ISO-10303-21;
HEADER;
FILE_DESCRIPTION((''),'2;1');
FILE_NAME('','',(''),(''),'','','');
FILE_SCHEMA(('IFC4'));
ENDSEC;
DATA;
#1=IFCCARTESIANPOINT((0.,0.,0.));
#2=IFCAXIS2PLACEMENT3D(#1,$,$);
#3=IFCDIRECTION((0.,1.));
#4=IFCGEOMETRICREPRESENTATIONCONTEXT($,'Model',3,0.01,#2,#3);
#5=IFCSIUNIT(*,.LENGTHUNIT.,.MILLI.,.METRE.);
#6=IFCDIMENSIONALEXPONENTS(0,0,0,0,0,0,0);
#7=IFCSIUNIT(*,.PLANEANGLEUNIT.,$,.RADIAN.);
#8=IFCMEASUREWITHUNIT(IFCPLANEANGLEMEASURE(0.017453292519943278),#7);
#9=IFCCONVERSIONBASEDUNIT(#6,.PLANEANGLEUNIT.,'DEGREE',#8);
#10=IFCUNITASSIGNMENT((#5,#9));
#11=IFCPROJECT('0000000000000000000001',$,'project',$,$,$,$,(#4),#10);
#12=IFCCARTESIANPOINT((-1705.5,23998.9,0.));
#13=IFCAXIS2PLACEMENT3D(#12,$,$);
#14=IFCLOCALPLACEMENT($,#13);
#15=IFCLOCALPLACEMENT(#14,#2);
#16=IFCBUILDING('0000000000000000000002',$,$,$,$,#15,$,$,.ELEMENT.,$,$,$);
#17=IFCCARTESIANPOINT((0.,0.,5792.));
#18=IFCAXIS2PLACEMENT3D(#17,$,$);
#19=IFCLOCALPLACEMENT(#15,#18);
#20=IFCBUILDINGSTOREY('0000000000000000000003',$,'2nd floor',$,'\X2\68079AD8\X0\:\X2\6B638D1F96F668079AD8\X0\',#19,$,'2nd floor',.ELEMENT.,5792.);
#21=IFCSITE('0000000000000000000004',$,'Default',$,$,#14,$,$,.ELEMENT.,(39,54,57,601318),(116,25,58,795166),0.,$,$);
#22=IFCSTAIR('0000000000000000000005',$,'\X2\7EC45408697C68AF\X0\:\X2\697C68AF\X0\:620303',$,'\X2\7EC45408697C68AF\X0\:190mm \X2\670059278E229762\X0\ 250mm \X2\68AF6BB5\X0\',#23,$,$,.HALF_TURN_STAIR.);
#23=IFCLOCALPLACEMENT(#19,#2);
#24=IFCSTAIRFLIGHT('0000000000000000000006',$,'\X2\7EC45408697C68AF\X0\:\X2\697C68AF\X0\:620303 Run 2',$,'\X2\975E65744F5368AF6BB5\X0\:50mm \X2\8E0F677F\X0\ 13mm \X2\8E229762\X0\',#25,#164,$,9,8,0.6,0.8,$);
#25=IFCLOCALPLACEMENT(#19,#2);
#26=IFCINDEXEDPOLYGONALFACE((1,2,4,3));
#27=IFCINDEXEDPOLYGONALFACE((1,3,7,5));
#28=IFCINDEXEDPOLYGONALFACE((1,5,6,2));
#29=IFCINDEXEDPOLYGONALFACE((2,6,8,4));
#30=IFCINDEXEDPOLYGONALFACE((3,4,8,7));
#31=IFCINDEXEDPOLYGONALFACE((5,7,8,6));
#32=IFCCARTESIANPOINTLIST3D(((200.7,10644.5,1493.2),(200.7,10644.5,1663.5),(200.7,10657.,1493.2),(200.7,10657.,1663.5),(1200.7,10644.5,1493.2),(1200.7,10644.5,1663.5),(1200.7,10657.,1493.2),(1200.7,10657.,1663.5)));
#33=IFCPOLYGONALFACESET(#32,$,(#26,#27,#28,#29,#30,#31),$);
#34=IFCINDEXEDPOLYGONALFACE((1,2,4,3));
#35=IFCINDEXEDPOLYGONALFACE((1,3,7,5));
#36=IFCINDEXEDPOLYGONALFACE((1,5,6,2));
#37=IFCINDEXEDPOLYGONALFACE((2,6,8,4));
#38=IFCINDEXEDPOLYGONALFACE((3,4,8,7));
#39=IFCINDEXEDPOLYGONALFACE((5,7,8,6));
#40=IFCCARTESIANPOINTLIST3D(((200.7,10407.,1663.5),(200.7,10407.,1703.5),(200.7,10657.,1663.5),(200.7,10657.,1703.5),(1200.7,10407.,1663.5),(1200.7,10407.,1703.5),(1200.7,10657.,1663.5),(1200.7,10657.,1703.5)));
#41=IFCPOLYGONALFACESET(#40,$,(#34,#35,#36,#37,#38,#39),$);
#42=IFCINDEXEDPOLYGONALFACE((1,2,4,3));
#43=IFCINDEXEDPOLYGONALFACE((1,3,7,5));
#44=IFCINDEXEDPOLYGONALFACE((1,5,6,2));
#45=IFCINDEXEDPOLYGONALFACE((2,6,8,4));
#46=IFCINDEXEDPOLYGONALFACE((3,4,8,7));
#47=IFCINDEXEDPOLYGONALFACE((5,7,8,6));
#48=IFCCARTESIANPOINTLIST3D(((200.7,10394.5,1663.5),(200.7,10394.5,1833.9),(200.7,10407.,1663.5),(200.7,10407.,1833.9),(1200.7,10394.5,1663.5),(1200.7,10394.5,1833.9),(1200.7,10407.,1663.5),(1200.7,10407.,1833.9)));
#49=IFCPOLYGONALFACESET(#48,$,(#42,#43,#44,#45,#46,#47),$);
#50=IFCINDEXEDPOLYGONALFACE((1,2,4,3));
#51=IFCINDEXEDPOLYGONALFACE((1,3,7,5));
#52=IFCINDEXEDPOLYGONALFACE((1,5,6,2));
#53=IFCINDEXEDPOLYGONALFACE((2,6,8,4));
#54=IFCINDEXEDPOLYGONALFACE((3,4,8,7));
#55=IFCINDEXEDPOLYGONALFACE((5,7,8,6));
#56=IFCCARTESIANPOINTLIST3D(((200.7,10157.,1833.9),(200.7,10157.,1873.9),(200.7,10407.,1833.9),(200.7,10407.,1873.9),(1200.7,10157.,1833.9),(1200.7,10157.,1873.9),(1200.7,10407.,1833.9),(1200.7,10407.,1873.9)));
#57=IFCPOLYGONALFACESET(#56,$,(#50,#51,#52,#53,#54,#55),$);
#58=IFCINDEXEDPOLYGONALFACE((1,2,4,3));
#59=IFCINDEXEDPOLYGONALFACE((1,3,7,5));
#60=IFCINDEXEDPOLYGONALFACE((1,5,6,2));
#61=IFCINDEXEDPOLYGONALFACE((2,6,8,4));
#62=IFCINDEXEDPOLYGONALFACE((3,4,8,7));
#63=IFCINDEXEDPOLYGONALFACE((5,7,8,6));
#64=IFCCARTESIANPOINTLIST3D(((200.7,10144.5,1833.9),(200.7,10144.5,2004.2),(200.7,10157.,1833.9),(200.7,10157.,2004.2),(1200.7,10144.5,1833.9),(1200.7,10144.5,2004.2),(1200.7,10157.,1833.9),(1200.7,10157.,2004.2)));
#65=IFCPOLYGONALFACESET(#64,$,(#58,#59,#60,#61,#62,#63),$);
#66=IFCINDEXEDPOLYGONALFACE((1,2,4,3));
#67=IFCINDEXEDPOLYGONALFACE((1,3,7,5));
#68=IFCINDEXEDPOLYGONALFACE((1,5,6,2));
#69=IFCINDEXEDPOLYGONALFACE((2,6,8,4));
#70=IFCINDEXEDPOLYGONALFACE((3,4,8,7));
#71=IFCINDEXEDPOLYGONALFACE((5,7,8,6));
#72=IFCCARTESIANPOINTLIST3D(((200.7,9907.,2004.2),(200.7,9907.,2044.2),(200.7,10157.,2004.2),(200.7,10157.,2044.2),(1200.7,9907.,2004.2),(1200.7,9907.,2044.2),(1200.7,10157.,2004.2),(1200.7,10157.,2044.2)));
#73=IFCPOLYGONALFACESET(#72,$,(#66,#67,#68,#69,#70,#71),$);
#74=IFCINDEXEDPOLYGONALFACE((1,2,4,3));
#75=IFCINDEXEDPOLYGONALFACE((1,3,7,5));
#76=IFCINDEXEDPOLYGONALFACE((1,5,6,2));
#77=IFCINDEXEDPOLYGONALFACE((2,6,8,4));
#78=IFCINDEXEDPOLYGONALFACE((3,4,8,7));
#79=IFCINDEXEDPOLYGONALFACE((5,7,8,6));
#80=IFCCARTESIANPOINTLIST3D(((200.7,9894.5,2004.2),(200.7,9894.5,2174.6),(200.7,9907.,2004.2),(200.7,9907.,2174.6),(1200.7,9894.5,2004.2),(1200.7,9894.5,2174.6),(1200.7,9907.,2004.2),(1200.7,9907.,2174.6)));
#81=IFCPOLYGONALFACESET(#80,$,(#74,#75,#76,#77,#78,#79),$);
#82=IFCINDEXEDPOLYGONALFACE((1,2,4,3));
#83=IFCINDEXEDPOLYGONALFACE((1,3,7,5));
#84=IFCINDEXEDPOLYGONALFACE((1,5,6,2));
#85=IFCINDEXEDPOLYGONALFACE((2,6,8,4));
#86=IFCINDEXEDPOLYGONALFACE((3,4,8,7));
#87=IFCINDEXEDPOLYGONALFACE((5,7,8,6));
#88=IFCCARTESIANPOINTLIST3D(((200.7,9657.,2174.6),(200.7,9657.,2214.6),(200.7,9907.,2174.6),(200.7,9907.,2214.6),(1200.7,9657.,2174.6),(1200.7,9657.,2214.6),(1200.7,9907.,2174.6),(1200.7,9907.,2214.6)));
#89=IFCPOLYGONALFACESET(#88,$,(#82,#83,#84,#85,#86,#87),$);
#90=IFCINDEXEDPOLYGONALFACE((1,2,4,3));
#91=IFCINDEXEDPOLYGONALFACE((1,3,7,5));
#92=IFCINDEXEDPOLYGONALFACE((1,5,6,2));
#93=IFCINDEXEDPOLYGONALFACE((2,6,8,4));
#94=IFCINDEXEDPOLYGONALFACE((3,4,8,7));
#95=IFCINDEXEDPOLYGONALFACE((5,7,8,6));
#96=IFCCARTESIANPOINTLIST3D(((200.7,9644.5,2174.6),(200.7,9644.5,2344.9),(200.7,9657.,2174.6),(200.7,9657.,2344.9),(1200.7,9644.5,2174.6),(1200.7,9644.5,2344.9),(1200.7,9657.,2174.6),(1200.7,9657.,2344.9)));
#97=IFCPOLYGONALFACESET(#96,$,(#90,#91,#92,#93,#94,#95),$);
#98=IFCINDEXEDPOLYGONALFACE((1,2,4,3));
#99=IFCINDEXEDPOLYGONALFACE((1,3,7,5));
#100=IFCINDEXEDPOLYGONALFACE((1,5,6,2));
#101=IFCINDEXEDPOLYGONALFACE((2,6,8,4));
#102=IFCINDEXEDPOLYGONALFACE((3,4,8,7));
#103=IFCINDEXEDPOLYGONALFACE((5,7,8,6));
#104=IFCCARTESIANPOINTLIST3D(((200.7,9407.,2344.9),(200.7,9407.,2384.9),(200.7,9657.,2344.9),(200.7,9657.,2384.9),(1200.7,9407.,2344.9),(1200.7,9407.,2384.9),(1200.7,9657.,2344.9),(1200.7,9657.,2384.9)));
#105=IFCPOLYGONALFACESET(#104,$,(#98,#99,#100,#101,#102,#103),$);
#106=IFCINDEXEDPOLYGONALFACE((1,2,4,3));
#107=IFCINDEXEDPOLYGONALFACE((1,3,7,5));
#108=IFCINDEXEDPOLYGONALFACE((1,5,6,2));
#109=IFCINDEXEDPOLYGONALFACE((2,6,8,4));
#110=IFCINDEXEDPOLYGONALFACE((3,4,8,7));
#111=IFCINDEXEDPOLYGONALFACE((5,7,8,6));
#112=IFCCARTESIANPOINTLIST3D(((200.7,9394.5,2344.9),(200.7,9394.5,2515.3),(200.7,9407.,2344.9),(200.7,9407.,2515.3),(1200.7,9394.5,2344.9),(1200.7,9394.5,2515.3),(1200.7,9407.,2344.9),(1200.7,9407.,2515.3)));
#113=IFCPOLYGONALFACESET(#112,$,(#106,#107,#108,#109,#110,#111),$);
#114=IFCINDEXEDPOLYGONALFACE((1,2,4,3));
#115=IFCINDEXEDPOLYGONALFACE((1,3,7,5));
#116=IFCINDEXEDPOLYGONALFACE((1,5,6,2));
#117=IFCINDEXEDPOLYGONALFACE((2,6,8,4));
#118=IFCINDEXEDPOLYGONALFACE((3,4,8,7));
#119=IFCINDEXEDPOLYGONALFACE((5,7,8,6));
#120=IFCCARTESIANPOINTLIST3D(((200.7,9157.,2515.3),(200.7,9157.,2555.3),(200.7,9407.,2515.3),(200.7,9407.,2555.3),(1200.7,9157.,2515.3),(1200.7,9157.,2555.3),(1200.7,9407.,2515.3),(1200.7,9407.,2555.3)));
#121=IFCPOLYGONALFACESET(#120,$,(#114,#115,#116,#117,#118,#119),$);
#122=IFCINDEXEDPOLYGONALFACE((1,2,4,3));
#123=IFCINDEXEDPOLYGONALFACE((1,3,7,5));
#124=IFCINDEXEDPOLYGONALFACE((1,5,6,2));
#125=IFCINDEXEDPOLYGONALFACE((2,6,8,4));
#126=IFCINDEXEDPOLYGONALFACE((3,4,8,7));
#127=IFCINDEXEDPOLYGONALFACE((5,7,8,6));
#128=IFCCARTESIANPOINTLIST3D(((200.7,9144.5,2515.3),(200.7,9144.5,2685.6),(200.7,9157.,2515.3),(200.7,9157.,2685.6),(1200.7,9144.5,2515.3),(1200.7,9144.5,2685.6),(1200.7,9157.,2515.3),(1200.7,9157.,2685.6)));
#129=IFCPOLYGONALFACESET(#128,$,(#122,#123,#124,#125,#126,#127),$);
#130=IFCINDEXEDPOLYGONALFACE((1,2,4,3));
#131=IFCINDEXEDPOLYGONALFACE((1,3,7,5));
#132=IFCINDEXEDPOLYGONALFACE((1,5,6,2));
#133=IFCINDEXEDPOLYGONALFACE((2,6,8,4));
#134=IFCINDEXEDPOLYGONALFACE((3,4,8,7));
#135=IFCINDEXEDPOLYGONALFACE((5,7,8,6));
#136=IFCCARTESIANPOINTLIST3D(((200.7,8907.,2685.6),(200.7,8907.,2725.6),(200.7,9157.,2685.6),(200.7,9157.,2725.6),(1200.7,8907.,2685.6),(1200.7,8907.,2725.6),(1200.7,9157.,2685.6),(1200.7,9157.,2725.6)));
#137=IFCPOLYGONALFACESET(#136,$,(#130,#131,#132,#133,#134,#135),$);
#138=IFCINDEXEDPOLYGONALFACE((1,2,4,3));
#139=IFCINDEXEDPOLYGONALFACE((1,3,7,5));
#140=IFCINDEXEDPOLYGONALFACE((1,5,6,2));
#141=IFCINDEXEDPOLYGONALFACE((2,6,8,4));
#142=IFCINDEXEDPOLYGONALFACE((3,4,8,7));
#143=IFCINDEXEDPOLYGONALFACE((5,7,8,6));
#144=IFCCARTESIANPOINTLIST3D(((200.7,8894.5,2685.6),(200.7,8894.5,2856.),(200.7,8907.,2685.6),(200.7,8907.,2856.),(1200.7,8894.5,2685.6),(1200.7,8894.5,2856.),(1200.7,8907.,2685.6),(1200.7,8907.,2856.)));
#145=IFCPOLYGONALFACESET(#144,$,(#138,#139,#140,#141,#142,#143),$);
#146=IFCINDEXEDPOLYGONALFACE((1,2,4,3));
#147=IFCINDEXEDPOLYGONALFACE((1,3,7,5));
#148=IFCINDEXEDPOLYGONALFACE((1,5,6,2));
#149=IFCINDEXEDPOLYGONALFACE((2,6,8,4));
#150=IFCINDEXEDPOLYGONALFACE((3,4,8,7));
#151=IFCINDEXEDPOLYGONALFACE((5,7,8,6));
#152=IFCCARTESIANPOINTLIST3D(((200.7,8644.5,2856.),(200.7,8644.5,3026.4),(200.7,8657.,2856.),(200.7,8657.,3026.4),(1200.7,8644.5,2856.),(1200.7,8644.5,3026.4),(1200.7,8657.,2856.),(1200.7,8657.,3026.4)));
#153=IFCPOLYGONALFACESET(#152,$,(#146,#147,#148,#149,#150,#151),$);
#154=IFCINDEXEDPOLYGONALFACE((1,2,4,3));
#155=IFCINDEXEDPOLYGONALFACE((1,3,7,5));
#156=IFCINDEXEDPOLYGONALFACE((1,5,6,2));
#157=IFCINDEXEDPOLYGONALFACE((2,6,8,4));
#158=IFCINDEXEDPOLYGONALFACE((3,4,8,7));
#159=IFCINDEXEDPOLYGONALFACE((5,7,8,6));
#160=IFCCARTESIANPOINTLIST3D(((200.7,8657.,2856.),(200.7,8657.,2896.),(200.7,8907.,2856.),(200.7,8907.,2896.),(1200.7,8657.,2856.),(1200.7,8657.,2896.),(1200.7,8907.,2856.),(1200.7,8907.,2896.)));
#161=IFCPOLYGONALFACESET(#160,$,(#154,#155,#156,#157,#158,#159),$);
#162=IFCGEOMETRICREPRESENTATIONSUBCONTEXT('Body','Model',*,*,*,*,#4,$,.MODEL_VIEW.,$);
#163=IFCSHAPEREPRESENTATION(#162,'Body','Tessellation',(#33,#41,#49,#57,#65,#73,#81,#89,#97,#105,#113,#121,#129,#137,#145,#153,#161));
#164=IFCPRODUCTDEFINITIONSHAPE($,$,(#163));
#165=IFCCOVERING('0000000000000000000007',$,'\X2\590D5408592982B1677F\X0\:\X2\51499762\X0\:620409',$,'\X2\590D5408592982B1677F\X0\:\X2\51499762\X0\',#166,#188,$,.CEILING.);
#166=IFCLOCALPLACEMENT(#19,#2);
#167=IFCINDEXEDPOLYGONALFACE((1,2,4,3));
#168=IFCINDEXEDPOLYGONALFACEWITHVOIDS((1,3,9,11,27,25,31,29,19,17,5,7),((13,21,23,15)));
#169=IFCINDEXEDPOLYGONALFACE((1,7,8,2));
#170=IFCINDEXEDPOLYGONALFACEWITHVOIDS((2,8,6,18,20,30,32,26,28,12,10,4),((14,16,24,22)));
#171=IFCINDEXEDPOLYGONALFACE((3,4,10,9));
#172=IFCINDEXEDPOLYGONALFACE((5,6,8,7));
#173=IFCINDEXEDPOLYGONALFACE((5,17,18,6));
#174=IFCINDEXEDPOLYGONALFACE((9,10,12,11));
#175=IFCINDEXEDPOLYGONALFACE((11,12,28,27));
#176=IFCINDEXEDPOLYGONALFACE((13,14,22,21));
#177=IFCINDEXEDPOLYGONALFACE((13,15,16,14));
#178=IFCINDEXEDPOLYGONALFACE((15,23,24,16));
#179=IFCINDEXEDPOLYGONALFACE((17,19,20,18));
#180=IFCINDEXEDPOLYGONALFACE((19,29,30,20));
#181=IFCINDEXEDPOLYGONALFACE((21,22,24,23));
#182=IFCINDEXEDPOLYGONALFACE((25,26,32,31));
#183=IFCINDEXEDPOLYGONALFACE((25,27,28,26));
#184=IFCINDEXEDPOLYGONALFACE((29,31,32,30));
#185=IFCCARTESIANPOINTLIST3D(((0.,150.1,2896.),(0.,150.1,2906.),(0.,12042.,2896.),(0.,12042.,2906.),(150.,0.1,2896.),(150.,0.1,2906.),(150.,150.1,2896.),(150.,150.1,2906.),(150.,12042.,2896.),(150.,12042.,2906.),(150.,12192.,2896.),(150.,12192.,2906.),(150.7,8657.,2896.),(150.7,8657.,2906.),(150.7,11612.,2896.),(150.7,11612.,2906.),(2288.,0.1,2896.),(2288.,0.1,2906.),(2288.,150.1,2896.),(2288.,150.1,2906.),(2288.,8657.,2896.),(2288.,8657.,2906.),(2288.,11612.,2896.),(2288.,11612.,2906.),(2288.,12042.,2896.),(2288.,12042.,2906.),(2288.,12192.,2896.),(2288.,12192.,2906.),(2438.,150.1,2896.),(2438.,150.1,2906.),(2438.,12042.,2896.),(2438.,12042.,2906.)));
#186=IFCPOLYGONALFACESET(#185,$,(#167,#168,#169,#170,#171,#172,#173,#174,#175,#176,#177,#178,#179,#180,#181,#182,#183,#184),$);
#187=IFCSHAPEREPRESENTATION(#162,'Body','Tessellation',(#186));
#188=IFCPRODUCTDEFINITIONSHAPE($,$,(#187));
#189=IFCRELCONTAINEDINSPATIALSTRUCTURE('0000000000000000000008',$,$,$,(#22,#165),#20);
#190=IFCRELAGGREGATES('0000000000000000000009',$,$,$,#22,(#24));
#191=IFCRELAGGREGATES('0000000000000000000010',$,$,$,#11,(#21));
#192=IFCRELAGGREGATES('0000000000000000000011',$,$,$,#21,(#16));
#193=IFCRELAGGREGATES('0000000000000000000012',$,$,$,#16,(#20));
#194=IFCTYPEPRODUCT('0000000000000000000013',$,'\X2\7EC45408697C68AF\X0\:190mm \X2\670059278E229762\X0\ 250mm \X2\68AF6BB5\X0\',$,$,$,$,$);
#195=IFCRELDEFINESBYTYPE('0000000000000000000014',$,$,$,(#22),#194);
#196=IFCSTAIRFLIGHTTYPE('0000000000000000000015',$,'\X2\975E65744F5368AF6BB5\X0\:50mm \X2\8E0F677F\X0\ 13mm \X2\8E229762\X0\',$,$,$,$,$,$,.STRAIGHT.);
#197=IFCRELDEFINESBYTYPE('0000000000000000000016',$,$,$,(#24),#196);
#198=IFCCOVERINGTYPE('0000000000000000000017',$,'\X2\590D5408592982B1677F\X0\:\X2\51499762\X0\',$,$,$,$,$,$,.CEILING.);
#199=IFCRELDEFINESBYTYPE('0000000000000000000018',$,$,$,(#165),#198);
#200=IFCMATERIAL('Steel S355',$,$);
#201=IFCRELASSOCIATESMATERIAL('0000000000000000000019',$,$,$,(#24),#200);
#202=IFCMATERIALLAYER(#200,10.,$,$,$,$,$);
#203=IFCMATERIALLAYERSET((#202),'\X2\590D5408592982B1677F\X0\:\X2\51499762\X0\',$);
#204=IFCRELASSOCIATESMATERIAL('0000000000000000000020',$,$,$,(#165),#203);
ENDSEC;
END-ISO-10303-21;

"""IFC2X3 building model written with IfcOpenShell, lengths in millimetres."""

from ifc_helpers import new_model, entity, si_unit, converted_unit, direction, frame, frame_2d, origin, origin_2d_with_axis, place, context, subcontext, project, spatial, polyline, rectangle, outline, extrude, material, layer, layer_set, layer_usage, type_object, element, aggregate, save


model = new_model("IFC2X3")

# Units and contexts
model_context = context("Model", 3, precision=0.01, world=origin(), true_north=direction((0.0, 1.0)))
body_context = subcontext(model_context, "Body", "Model", "MODEL_VIEW")
ifc_project = project(units=[si_unit("LENGTHUNIT", "METRE", prefix="MILLI"), converted_unit("PLANEANGLEUNIT", "DEGREE", entity("IfcPlaneAngleMeasure", 0.017453292519943278), si_unit("PLANEANGLEUNIT", "RADIAN"), dimensions=[0, 0, 0, 0, 0, 0, 0])], contexts=[model_context])

# Site, building, storey
site_placement = place(None, frame((-1705.5, 23998.9, 0.0)))
site = spatial("IfcSite", under=ifc_project, at=site_placement, Name="Default", CompositionType="ELEMENT", RefLatitude=(39, 54, 57, 601318), RefLongitude=(116, 25, 58, 795166), RefElevation=0.0)
building_placement = place(site_placement, origin())
building = spatial("IfcBuilding", under=site, at=building_placement, CompositionType="ELEMENT")
storey_placement = place(building_placement, frame((0.0, 0.0, 5792.0)))
storey = spatial("IfcBuildingStorey", under=building, at=storey_placement, Name="2nd floor", ObjectType="标高:正负零标高", LongName="2nd floor", CompositionType="ELEMENT", Elevation=5792.0)

# Stair
type_product = type_object("IfcTypeProduct", Name="组合楼梯:190mm 最大踢面 250mm 梯段")
stair_placement = place(storey_placement, origin())
stair = element("IfcStair", 1, at=stair_placement, inside=storey, type_object=type_product, Name="组合楼梯:楼梯:620303", ObjectType="组合楼梯:190mm 最大踢面 250mm 梯段", ShapeType="HALF_TURN_STAIR")
ifc_material_1 = material(Name="Steel S355")

# Stair flight
stair_flight_type = type_object("IfcStairFlightType", Name="非整体梯段:50mm 踏板 13mm 踢面", PredefinedType="STRAIGHT")
stair_flight_1_placement = place(stair_placement, origin())
stair_flight_1 = element("IfcStairFlight", 2, at=stair_flight_1_placement, type_object=stair_flight_type, material=ifc_material_1, Name="组合楼梯:楼梯:620303 Run 2", ObjectType="非整体梯段:50mm 踏板 13mm 踢面", NumberOfRiser=9, NumberOfTreads=8, RiserHeight=0.6, TreadLength=0.8, context=body_context, shape_type="SweptSolid", body=[
    extrude(rectangle(XDim=1000.0, YDim=12.5, at=frame_2d((0.0, 0.0), x_axis=(1.0, 0.0))), frame((700.7, 10650.7, 1493.2)), (0.0, 0.0, 1.0), 170.4),
    extrude(rectangle(XDim=250.0, YDim=1000.0, at=frame_2d((0.0, 0.0), x_axis=(1.0, 0.0))), frame((700.7, 10532.0, 1663.5), z_axis=(0.0, 0.0, 1.0), x_axis=(0.0, 1.0, 0.0)), (0.0, 0.0, 1.0), 40.0),
    extrude(rectangle(XDim=1000.0, YDim=12.5, at=frame_2d((0.0, 0.0), x_axis=(1.0, 0.0))), frame((700.7, 10400.7, 1663.5)), (0.0, 0.0, 1.0), 170.4),
    extrude(rectangle(XDim=250.0, YDim=1000.0, at=origin_2d_with_axis()), frame((700.7, 10282.0, 1833.9), z_axis=(0.0, 0.0, 1.0), x_axis=(0.0, 1.0, 0.0)), (0.0, 0.0, 1.0), 40.0),
    extrude(rectangle(XDim=1000.0, YDim=12.5, at=frame_2d((0.0, 0.0), x_axis=(1.0, 0.0))), frame((700.7, 10150.7, 1833.9)), (0.0, 0.0, 1.0), 170.4),
    extrude(rectangle(XDim=250.0, YDim=1000.0, at=frame_2d((0.0, 0.0), x_axis=(1.0, 0.0))), frame((700.7, 10032.0, 2004.2), z_axis=(0.0, 0.0, 1.0), x_axis=(0.0, 1.0, 0.0)), (0.0, 0.0, 1.0), 40.0),
    extrude(rectangle(XDim=1000.0, YDim=12.5, at=frame_2d((0.0, 0.0), x_axis=(1.0, 0.0))), frame((700.7, 9900.7, 2004.2)), (0.0, 0.0, 1.0), 170.4),
    extrude(rectangle(XDim=250.0, YDim=1000.0, at=origin_2d_with_axis()), frame((700.7, 9782.0, 2174.6), z_axis=(0.0, 0.0, 1.0), x_axis=(0.0, 1.0, 0.0)), (0.0, 0.0, 1.0), 40.0),
    extrude(rectangle(XDim=1000.0, YDim=12.5, at=frame_2d((0.0, 0.0), x_axis=(1.0, 0.0))), frame((700.7, 9650.7, 2174.6)), (0.0, 0.0, 1.0), 170.4),
    extrude(rectangle(XDim=250.0, YDim=1000.0, at=frame_2d((0.0, 0.0), x_axis=(1.0, 0.0))), frame((700.7, 9532.0, 2344.9), z_axis=(0.0, 0.0, 1.0), x_axis=(0.0, 1.0, 0.0)), (0.0, 0.0, 1.0), 40.0),
    extrude(rectangle(XDim=1000.0, YDim=12.5, at=frame_2d((0.0, 0.0), x_axis=(1.0, 0.0))), frame((700.7, 9400.7, 2344.9)), (0.0, 0.0, 1.0), 170.4),
    extrude(rectangle(XDim=250.0, YDim=1000.0, at=origin_2d_with_axis()), frame((700.7, 9282.0, 2515.3), z_axis=(0.0, 0.0, 1.0), x_axis=(0.0, 1.0, 0.0)), (0.0, 0.0, 1.0), 40.0),
    extrude(rectangle(XDim=1000.0, YDim=12.5, at=frame_2d((0.0, 0.0), x_axis=(1.0, 0.0))), frame((700.7, 9150.7, 2515.3)), (0.0, 0.0, 1.0), 170.4),
    extrude(rectangle(XDim=250.0, YDim=1000.0, at=frame_2d((0.0, 0.0), x_axis=(1.0, 0.0))), frame((700.7, 9032.0, 2685.6), z_axis=(0.0, 0.0, 1.0), x_axis=(0.0, 1.0, 0.0)), (0.0, 0.0, 1.0), 40.0),
    extrude(rectangle(XDim=1000.0, YDim=12.5, at=frame_2d((0.0, 0.0), x_axis=(1.0, 0.0))), frame((700.7, 8900.7, 2685.6)), (0.0, 0.0, 1.0), 170.4),
    extrude(rectangle(XDim=1000.0, YDim=12.5, at=frame_2d((0.0, 0.0), x_axis=(1.0, 0.0))), frame((700.7, 8650.7, 2856.0)), (0.0, 0.0, 1.0), 170.4),
    extrude(rectangle(XDim=250.0, YDim=1000.0, at=origin_2d_with_axis()), frame((700.7, 8782.0, 2856.0), z_axis=(0.0, 0.0, 1.0), x_axis=(0.0, 1.0, 0.0)), (0.0, 0.0, 1.0), 40.0),
])
aggregate(stair, [stair_flight_1])

# Covering
ifc_layer_1 = layer(ifc_material_1, 10.0)
ifc_layer_set_1 = layer_set([ifc_layer_1], Name="复合天花板:光面")
ifc_layer_usage_1 = layer_usage(ifc_layer_set_1, "AXIS3", "NEGATIVE", 10.0)
covering_type = type_object("IfcCoveringType", Name="复合天花板:光面", PredefinedType="CEILING")
covering_placement = place(storey_placement, origin())
element("IfcCovering", 3, at=covering_placement, inside=storey, type_object=covering_type, material=ifc_layer_usage_1, Name="复合天花板:光面:620409", ObjectType="复合天花板:光面", PredefinedType="CEILING", context=body_context, shape_type="SweptSolid", body=[
    extrude(outline(polyline([(5946.0, -1069.0), (6096.0, -1069.0), (6096.0, 1069.0), (5945.9, 1069.0), (5945.9, 1219.0), (-5946.0, 1219.0), (-5946.0, 1069.0), (-6096.0, 1069.0), (-6096.0, -1069.0), (-5946.0, -1069.0), (-5946.0, -1219.0), (5946.0, -1219.0), (5946.0, -1069.0)]), holes=[polyline([(5516.0, 1068.3), (5516.0, -1069.0), (2561.0, -1069.0), (2561.0, 1068.3), (5516.0, 1068.3)])]), frame((1219.0, 6096.0, 2896.0), z_axis=(0.0, 0.0, 1.0), x_axis=(0.0, 1.0, 0.0)), (0.0, 0.0, 1.0), 10.0),
])

save(model, "model.ifc")
